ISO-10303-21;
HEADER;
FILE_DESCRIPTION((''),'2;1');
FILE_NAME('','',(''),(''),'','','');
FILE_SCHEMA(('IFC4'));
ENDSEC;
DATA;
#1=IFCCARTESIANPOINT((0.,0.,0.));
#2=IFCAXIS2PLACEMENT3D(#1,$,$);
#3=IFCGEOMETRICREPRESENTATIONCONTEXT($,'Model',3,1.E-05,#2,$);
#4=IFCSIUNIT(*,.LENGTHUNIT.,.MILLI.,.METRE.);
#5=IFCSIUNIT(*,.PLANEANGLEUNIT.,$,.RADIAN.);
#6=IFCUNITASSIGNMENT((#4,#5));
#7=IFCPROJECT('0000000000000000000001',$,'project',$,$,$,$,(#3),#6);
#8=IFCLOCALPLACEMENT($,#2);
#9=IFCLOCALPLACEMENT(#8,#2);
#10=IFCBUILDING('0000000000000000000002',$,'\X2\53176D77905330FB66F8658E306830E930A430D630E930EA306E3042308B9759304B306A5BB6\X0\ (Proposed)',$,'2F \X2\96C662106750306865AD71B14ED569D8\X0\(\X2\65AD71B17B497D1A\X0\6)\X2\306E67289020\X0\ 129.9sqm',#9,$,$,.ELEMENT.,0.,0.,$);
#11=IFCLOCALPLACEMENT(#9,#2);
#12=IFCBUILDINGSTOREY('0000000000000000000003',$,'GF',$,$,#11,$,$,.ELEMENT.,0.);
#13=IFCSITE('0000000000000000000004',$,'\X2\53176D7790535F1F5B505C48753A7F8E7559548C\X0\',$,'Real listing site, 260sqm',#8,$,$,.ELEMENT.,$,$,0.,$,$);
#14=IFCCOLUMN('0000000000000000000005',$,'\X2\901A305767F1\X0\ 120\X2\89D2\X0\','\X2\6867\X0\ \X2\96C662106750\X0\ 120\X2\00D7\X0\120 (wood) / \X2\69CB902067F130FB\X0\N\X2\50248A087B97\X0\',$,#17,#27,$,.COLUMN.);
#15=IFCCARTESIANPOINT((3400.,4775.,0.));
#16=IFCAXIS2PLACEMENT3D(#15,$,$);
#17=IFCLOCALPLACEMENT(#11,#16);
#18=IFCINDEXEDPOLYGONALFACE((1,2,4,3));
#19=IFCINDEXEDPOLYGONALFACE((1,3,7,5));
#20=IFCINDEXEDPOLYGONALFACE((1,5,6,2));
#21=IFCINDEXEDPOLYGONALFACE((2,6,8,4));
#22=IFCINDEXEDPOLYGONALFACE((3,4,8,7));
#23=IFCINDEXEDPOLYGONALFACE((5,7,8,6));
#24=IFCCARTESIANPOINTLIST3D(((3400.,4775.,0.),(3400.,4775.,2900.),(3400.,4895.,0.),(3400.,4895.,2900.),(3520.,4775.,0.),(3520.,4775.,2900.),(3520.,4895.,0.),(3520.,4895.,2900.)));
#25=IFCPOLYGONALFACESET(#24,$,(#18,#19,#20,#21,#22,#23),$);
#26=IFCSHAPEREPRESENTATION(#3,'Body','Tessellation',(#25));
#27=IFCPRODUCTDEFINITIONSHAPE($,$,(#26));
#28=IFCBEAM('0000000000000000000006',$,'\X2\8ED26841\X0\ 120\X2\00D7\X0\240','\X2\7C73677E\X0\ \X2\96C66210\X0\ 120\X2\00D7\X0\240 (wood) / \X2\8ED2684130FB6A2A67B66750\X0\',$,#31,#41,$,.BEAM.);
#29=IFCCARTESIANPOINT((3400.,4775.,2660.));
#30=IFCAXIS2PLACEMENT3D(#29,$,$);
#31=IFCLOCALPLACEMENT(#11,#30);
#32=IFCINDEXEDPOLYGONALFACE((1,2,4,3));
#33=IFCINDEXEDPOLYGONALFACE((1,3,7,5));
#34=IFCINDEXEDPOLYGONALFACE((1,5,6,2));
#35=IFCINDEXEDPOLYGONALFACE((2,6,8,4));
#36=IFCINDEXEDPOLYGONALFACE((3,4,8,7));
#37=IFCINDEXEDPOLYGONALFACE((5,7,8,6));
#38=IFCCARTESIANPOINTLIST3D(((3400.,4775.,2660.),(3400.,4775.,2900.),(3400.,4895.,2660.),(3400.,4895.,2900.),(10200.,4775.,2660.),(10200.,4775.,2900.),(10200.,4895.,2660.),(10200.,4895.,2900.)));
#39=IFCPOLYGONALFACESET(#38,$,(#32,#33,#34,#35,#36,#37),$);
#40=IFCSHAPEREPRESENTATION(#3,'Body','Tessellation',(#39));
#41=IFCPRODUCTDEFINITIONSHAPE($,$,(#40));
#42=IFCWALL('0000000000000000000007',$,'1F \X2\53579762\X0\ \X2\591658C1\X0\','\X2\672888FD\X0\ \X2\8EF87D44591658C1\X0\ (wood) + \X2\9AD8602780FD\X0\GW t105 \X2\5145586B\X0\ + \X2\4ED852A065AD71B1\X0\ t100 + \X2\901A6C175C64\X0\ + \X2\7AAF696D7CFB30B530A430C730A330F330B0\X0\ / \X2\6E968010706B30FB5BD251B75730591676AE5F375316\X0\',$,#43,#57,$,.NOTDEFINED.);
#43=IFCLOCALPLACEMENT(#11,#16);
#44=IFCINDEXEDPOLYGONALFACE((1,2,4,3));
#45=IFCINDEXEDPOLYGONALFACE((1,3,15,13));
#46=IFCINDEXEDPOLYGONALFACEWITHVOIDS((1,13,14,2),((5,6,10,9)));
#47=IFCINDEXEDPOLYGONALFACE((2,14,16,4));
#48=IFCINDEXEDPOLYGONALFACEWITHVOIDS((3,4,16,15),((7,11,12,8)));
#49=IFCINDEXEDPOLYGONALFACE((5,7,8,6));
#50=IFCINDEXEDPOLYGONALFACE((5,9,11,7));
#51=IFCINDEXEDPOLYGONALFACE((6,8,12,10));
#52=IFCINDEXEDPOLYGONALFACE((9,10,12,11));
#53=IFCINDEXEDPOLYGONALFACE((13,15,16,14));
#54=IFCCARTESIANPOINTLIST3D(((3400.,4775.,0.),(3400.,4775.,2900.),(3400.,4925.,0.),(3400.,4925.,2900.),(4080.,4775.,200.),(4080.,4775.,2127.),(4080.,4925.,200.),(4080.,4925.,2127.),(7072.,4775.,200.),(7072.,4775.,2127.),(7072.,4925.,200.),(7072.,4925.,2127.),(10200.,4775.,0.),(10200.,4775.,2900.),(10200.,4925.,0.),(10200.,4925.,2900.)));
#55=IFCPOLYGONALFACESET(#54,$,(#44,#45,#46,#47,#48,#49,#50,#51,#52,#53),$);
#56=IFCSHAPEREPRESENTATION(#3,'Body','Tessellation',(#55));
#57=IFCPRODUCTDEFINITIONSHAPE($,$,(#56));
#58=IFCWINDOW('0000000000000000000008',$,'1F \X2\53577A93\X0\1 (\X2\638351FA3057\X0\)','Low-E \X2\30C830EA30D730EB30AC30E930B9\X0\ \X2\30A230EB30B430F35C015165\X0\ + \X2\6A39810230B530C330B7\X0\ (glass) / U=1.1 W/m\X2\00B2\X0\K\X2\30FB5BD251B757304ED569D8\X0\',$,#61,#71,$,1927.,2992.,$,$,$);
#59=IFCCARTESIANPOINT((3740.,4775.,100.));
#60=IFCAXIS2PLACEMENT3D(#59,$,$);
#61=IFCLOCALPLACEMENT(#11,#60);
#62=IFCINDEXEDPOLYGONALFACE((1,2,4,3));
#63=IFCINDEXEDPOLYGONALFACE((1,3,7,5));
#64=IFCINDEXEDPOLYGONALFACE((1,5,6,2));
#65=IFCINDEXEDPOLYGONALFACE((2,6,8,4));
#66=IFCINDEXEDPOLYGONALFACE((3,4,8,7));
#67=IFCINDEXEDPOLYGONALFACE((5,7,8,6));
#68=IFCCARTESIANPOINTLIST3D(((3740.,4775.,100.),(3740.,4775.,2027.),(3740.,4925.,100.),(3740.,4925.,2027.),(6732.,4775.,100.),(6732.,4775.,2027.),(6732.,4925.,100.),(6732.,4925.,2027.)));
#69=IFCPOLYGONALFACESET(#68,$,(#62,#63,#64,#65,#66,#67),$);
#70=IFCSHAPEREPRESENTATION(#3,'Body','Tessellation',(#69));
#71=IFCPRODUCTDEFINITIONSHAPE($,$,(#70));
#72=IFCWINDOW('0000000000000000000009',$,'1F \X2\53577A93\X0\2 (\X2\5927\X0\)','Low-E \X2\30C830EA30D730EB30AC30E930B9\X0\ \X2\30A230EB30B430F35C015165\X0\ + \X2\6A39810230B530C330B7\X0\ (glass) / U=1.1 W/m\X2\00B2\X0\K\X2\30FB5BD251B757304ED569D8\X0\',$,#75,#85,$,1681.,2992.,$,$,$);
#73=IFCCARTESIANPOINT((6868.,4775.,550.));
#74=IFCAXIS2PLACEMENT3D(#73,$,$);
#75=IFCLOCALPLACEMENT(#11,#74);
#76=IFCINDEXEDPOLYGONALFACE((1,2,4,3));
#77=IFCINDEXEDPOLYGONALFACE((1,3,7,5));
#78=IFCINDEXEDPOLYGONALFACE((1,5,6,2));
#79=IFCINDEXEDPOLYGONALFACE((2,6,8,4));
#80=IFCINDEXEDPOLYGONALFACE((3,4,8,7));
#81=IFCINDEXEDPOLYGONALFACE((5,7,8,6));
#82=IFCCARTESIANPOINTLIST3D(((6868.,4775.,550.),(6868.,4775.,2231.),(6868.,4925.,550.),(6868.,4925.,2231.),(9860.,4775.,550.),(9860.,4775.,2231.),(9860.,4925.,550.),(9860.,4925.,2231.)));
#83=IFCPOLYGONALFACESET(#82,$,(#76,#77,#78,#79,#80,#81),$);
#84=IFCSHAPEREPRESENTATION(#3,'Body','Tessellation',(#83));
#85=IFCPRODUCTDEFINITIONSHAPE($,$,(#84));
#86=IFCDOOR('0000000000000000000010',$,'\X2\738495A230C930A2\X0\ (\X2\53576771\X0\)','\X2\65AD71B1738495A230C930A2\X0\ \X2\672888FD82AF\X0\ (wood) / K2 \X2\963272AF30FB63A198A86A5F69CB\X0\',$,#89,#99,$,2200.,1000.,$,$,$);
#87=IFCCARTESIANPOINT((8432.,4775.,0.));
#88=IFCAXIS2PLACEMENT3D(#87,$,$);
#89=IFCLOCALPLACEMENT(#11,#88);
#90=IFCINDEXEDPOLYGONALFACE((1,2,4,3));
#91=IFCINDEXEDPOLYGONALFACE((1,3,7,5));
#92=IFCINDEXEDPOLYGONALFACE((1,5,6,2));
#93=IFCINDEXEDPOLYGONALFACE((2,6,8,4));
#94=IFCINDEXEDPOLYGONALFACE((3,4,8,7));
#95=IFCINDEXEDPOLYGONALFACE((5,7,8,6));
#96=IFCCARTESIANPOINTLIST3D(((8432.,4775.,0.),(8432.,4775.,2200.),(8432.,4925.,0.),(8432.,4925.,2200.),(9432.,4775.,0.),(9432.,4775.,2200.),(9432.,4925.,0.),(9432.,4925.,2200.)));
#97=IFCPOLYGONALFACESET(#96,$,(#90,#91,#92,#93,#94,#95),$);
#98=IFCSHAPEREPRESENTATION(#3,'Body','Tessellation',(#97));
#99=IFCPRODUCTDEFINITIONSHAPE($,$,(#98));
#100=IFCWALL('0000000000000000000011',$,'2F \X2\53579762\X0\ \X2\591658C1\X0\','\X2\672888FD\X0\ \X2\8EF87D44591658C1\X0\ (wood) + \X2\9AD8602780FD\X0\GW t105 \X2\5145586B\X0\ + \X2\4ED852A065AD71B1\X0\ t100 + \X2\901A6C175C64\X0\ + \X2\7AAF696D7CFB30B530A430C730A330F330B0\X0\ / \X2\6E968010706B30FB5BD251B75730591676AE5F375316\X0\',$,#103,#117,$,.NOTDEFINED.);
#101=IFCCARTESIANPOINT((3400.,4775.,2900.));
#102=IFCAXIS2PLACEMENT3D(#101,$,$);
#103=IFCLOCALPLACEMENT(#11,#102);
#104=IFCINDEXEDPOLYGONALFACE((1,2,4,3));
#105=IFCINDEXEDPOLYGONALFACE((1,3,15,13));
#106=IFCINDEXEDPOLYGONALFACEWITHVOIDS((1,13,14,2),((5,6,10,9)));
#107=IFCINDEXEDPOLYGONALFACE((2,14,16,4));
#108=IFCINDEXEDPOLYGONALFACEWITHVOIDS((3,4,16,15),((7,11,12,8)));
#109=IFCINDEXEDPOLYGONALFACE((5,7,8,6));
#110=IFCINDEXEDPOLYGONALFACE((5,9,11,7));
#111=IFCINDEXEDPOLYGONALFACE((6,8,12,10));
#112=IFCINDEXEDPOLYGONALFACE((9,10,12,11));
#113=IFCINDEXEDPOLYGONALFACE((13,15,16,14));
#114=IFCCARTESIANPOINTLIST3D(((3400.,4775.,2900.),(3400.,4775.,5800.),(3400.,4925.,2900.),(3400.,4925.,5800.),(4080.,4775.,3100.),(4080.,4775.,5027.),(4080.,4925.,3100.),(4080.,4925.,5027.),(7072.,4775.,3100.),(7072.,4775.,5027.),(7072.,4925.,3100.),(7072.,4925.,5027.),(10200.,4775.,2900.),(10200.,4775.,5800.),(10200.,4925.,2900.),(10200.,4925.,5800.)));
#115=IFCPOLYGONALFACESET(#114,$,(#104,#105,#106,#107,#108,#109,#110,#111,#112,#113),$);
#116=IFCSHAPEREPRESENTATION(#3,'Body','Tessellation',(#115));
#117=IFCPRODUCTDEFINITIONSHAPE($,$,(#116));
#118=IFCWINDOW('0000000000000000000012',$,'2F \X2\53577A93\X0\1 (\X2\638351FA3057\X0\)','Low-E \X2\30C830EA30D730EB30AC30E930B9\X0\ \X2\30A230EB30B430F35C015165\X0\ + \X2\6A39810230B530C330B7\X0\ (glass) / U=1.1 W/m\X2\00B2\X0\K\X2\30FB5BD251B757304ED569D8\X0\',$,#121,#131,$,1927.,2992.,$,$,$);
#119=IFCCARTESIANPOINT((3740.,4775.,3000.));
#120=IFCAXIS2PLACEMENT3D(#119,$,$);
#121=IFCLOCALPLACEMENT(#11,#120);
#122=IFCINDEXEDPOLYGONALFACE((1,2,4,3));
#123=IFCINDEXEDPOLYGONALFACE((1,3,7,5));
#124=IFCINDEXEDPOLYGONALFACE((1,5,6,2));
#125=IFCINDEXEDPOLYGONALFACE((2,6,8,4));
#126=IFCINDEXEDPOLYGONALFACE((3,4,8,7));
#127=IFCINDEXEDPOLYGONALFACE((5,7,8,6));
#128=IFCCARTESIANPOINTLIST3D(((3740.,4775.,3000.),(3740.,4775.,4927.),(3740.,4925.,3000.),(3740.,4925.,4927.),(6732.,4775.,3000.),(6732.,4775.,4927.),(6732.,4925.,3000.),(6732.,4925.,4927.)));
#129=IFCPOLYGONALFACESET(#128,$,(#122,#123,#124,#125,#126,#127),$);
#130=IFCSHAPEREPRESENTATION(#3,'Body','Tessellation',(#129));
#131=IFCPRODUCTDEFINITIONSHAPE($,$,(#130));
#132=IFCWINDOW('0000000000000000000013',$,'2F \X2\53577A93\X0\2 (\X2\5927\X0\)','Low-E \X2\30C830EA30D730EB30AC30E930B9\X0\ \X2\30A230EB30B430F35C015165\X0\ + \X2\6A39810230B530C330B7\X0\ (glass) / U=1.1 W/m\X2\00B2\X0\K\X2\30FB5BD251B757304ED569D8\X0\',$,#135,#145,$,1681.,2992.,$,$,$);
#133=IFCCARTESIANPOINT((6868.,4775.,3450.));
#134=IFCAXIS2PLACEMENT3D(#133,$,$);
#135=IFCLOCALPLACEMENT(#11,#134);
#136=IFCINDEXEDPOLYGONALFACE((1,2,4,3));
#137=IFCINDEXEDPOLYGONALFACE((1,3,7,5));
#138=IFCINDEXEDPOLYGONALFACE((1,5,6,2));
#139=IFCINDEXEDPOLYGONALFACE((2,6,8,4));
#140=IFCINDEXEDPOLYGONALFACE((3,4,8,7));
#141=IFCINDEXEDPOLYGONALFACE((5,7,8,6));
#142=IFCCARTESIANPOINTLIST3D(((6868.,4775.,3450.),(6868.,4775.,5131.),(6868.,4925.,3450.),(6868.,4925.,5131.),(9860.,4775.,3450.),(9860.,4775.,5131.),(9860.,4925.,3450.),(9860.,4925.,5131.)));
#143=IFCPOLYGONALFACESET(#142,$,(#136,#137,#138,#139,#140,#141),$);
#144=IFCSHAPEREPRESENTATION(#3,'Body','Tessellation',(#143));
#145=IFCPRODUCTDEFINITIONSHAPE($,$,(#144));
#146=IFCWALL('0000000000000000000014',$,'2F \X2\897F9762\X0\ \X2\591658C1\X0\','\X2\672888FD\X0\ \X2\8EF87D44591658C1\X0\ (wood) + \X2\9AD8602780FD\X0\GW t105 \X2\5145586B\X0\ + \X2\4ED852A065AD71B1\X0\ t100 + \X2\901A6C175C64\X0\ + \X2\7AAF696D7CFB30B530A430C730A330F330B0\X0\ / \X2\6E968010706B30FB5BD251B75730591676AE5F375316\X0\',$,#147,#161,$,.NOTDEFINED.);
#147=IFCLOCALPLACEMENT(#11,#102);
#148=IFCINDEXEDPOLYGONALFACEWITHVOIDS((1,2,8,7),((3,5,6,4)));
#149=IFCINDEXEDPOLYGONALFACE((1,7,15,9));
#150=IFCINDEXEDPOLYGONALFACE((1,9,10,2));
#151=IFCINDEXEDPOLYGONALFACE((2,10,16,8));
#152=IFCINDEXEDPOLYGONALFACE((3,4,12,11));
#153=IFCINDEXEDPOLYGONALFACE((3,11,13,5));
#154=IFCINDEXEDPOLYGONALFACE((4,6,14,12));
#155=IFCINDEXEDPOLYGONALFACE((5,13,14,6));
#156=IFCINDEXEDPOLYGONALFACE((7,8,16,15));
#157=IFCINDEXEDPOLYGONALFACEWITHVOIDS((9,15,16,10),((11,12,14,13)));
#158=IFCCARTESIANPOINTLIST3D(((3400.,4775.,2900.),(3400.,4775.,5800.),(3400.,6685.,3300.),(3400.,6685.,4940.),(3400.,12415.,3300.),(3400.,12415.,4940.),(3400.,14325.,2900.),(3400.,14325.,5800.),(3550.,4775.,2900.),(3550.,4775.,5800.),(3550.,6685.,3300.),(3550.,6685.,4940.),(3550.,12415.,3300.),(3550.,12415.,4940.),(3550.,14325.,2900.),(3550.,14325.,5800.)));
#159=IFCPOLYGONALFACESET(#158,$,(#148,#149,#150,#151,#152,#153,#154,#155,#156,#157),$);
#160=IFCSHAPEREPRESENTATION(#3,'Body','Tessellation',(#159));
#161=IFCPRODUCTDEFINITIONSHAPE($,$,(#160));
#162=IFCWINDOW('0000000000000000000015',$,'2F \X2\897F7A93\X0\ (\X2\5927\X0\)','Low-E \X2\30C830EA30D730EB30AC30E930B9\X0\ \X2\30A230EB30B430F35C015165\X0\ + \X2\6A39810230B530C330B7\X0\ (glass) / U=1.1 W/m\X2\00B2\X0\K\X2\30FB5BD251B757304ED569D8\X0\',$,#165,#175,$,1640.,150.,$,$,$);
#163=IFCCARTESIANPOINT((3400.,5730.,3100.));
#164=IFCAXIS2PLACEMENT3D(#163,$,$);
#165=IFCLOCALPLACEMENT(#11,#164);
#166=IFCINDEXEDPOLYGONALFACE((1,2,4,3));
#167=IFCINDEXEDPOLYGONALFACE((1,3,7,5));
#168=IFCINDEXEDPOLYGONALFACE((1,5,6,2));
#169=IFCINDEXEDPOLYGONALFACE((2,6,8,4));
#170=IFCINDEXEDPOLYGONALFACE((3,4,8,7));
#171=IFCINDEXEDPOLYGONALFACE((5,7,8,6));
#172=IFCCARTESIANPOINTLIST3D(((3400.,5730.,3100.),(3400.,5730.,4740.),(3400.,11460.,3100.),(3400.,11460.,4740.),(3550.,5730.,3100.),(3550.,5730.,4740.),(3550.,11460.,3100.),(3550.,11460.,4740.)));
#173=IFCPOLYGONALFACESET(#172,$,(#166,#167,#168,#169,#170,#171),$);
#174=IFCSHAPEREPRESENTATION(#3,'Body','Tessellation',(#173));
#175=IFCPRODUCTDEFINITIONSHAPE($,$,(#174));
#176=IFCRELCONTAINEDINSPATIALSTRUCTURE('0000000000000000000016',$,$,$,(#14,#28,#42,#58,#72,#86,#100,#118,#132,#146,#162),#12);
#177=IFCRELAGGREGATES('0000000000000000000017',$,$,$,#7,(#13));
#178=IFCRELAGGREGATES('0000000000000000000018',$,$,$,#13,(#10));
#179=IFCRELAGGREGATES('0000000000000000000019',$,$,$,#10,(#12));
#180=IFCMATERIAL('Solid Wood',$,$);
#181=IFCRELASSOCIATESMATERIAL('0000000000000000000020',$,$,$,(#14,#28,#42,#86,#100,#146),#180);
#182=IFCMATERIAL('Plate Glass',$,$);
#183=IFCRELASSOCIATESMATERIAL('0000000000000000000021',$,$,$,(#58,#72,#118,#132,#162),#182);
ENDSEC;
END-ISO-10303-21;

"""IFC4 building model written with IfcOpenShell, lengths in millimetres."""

from ifc_helpers import new_model, si_unit, frame, frame_2d, origin, place, context, project, spatial, rectangle, extrude, material, element, fill, save


model = new_model("IFC4")

# Units and contexts
model_context = context("Model", 3, precision=1e-05, world=origin())
ifc_project = project(units=[si_unit("LENGTHUNIT", "METRE", prefix="MILLI"), si_unit("PLANEANGLEUNIT", "RADIAN")], contexts=[model_context])

# Site, building, storey
site_placement = place(None, origin())
site = spatial("IfcSite", under=ifc_project, at=site_placement, Name="北海道弟子屈町美留和", ObjectType="Real listing site, 260sqm", CompositionType="ELEMENT", RefElevation=0.0)
building_placement = place(site_placement, origin())
building = spatial("IfcBuilding", under=site, at=building_placement, Name="北海道・書斎とライブラリのある静かな家 (Proposed)", ObjectType="2F 集成材と断熱仕様(断熱等級6)の木造 129.9sqm", CompositionType="ELEMENT", ElevationOfRefHeight=0.0, ElevationOfTerrain=0.0)
storey_placement = place(building_placement, origin())
storey = spatial("IfcBuildingStorey", under=building, at=storey_placement, Name="GF", CompositionType="ELEMENT", Elevation=0.0)

# Column
ifc_material_1 = material(Name="Solid Wood")
column_placement = place(storey_placement, frame((3400.0, 4775.0, 0.0)))
element("IfcColumn", 1, at=column_placement, inside=storey, material=ifc_material_1, Name="通し柱 120角", Description="桧 集成材 120×120 (wood) / 構造柱・N値計算", PredefinedType="COLUMN", context=model_context, shape_type="SweptSolid", body=[
    extrude(rectangle(XDim=120.0, YDim=120.0, at=frame_2d((60.0, 60.0))), frame((3400.0, 4775.0, 0.0)), (0.0, 0.0, 1.0), 2900.0),
])

# Beam
beam_1_placement = place(storey_placement, frame((3400.0, 4775.0, 2660.0)))
element("IfcBeam", 2, at=beam_1_placement, inside=storey, material=ifc_material_1, Name="軒桁 120×240", Description="米松 集成 120×240 (wood) / 軒桁・横架材", PredefinedType="BEAM", context=model_context, shape_type="SweptSolid", body=[
    extrude(rectangle(XDim=6800.0, YDim=120.0, at=frame_2d((3400.0, 60.0))), frame((3400.0, 4775.0, 2660.0)), (0.0, 0.0, 1.0), 240.0),
])

# Wall, openings, windows, door
wall_1_placement = place(storey_placement, frame((3400.0, 4775.0, 0.0)))
wall_1 = element("IfcWall", 3, at=wall_1_placement, inside=storey, material=ifc_material_1, Name="1F 南面 外壁", Description="木製 軸組外壁 (wood) + 高性能GW t105 充填 + 付加断熱 t100 + 通気層 + 窯業系サイディング / 準耐火・寒冷地外皮強化", PredefinedType="NOTDEFINED", context=model_context, shape_type="SweptSolid", body=[
    extrude(rectangle(XDim=6800.0, YDim=150.0, at=frame_2d((3400.0, 75.0))), frame((3400.0, 4775.0, 0.0)), (0.0, 0.0, 1.0), 2900.0),
])
opening_1_placement = place(storey_placement, frame((3740.0, 4775.0, 100.0)))
opening_1 = element("IfcOpeningElement", 4, at=opening_1_placement, cuts=wall_1, PredefinedType="NOTDEFINED", context=model_context, shape_type="SweptSolid", body=[
    extrude(rectangle(XDim=2992.0, YDim=150.0, at=frame_2d((1496.0, 75.0))), frame((3740.0, 4775.0, 100.0)), (0.0, 0.0, 1.0), 1927.0),
])
opening_2_placement = place(storey_placement, frame((6868.0, 4775.0, 550.0)))
opening_2 = element("IfcOpeningElement", 5, at=opening_2_placement, cuts=wall_1, PredefinedType="NOTDEFINED", context=model_context, shape_type="SweptSolid", body=[
    extrude(rectangle(XDim=2992.0, YDim=150.0, at=frame_2d((1496.0, 75.0))), frame((6868.0, 4775.0, 550.0)), (0.0, 0.0, 1.0), 1681.0),
])
opening_3_placement = place(storey_placement, frame((8432.0, 4775.0, 0.0)))
opening_3 = element("IfcOpeningElement", 6, at=opening_3_placement, cuts=wall_1, PredefinedType="NOTDEFINED", context=model_context, shape_type="SweptSolid", body=[
    extrude(rectangle(XDim=1000.0, YDim=150.0, at=frame_2d((500.0, 75.0))), frame((8432.0, 4775.0, 0.0)), (0.0, 0.0, 1.0), 2200.0),
])
ifc_material_2 = material(Name="Plate Glass")
window_1_placement = place(storey_placement, frame((3740.0, 4775.0, 100.0)))
window_1 = element("IfcWindow", 7, at=window_1_placement, inside=storey, material=ifc_material_2, Name="1F 南窓1 (掃出し)", Description="Low-E トリプルガラス アルゴン封入 + 樹脂サッシ (glass) / U=1.1 W/m²K・寒冷地仕様", OverallHeight=1927.0, OverallWidth=2992.0, context=model_context, shape_type="SweptSolid", body=[
    extrude(rectangle(XDim=2992.0, YDim=150.0, at=frame_2d((1496.0, 75.0))), frame((3740.0, 4775.0, 100.0)), (0.0, 0.0, 1.0), 1927.0),
])
fill(opening_1, window_1)
window_2_placement = place(storey_placement, frame((6868.0, 4775.0, 550.0)))
window_2 = element("IfcWindow", 8, at=window_2_placement, inside=storey, material=ifc_material_2, Name="1F 南窓2 (大)", Description="Low-E トリプルガラス アルゴン封入 + 樹脂サッシ (glass) / U=1.1 W/m²K・寒冷地仕様", OverallHeight=1681.0, OverallWidth=2992.0, context=model_context, shape_type="SweptSolid", body=[
    extrude(rectangle(XDim=2992.0, YDim=150.0, at=frame_2d((1496.0, 75.0))), frame((6868.0, 4775.0, 550.0)), (0.0, 0.0, 1.0), 1681.0),
])
fill(opening_2, window_2)
door_placement = place(storey_placement, frame((8432.0, 4775.0, 0.0)))
door = element("IfcDoor", 9, at=door_placement, inside=storey, material=ifc_material_1, Name="玄関ドア (南東)", Description="断熱玄関ドア 木製芯 (wood) / K2 防犯・採風機構", OverallHeight=2200.0, OverallWidth=1000.0, context=model_context, shape_type="SweptSolid", body=[
    extrude(rectangle(XDim=1000.0, YDim=150.0, at=frame_2d((500.0, 75.0))), frame((8432.0, 4775.0, 0.0)), (0.0, 0.0, 1.0), 2200.0),
])
fill(opening_3, door)

# Wall, openings, windows
wall_2_placement = place(storey_placement, frame((3400.0, 4775.0, 2900.0)))
wall_2 = element("IfcWall", 10, at=wall_2_placement, inside=storey, material=ifc_material_1, Name="2F 南面 外壁", Description="木製 軸組外壁 (wood) + 高性能GW t105 充填 + 付加断熱 t100 + 通気層 + 窯業系サイディング / 準耐火・寒冷地外皮強化", PredefinedType="NOTDEFINED", context=model_context, shape_type="SweptSolid", body=[
    extrude(rectangle(XDim=6800.0, YDim=150.0, at=frame_2d((3400.0, 75.0))), frame((3400.0, 4775.0, 2900.0)), (0.0, 0.0, 1.0), 2900.0),
])
opening_4_placement = place(storey_placement, frame((3740.0, 4775.0, 3000.0)))
opening_4 = element("IfcOpeningElement", 11, at=opening_4_placement, cuts=wall_2, PredefinedType="NOTDEFINED", context=model_context, shape_type="SweptSolid", body=[
    extrude(rectangle(XDim=2992.0, YDim=150.0, at=frame_2d((1496.0, 75.0))), frame((3740.0, 4775.0, 3000.0)), (0.0, 0.0, 1.0), 1927.0),
])
opening_5_placement = place(storey_placement, frame((6868.0, 4775.0, 3450.0)))
opening_5 = element("IfcOpeningElement", 12, at=opening_5_placement, cuts=wall_2, PredefinedType="NOTDEFINED", context=model_context, shape_type="SweptSolid", body=[
    extrude(rectangle(XDim=2992.0, YDim=150.0, at=frame_2d((1496.0, 75.0))), frame((6868.0, 4775.0, 3450.0)), (0.0, 0.0, 1.0), 1681.0),
])
window_3_placement = place(storey_placement, frame((3740.0, 4775.0, 3000.0)))
window_3 = element("IfcWindow", 13, at=window_3_placement, inside=storey, material=ifc_material_2, Name="2F 南窓1 (掃出し)", Description="Low-E トリプルガラス アルゴン封入 + 樹脂サッシ (glass) / U=1.1 W/m²K・寒冷地仕様", OverallHeight=1927.0, OverallWidth=2992.0, context=model_context, shape_type="SweptSolid", body=[
    extrude(rectangle(XDim=2992.0, YDim=150.0, at=frame_2d((1496.0, 75.0))), frame((3740.0, 4775.0, 3000.0)), (0.0, 0.0, 1.0), 1927.0),
])
fill(opening_4, window_3)
window_4_placement = place(storey_placement, frame((6868.0, 4775.0, 3450.0)))
window_4 = element("IfcWindow", 14, at=window_4_placement, inside=storey, material=ifc_material_2, Name="2F 南窓2 (大)", Description="Low-E トリプルガラス アルゴン封入 + 樹脂サッシ (glass) / U=1.1 W/m²K・寒冷地仕様", OverallHeight=1681.0, OverallWidth=2992.0, context=model_context, shape_type="SweptSolid", body=[
    extrude(rectangle(XDim=2992.0, YDim=150.0, at=frame_2d((1496.0, 75.0))), frame((6868.0, 4775.0, 3450.0)), (0.0, 0.0, 1.0), 1681.0),
])
fill(opening_5, window_4)

# Wall, opening, window
wall_3_placement = place(storey_placement, frame((3400.0, 4775.0, 2900.0)))
wall_3 = element("IfcWall", 15, at=wall_3_placement, inside=storey, material=ifc_material_1, Name="2F 西面 外壁", Description="木製 軸組外壁 (wood) + 高性能GW t105 充填 + 付加断熱 t100 + 通気層 + 窯業系サイディング / 準耐火・寒冷地外皮強化", PredefinedType="NOTDEFINED", context=model_context, shape_type="SweptSolid", body=[
    extrude(rectangle(XDim=150.0, YDim=9550.0, at=frame_2d((75.0, 4775.0))), frame((3400.0, 4775.0, 2900.0)), (0.0, 0.0, 1.0), 2900.0),
])
opening_6_placement = place(storey_placement, frame((3400.0, 5730.0, 3100.0)))
opening_6 = element("IfcOpeningElement", 16, at=opening_6_placement, cuts=wall_3, PredefinedType="NOTDEFINED", context=model_context, shape_type="SweptSolid", body=[
    extrude(rectangle(XDim=150.0, YDim=5730.0, at=frame_2d((75.0, 2865.0))), frame((3400.0, 5730.0, 3100.0)), (0.0, 0.0, 1.0), 1640.0),
])
window_5_placement = place(storey_placement, frame((3400.0, 5730.0, 3100.0)))
window_5 = element("IfcWindow", 17, at=window_5_placement, inside=storey, material=ifc_material_2, Name="2F 西窓 (大)", Description="Low-E トリプルガラス アルゴン封入 + 樹脂サッシ (glass) / U=1.1 W/m²K・寒冷地仕様", OverallHeight=1640.0, OverallWidth=150.0, context=model_context, shape_type="SweptSolid", body=[
    extrude(rectangle(XDim=150.0, YDim=5730.0, at=frame_2d((75.0, 2865.0))), frame((3400.0, 5730.0, 3100.0)), (0.0, 0.0, 1.0), 1640.0),
])
fill(opening_6, window_5)

save(model, "model.ifc")
